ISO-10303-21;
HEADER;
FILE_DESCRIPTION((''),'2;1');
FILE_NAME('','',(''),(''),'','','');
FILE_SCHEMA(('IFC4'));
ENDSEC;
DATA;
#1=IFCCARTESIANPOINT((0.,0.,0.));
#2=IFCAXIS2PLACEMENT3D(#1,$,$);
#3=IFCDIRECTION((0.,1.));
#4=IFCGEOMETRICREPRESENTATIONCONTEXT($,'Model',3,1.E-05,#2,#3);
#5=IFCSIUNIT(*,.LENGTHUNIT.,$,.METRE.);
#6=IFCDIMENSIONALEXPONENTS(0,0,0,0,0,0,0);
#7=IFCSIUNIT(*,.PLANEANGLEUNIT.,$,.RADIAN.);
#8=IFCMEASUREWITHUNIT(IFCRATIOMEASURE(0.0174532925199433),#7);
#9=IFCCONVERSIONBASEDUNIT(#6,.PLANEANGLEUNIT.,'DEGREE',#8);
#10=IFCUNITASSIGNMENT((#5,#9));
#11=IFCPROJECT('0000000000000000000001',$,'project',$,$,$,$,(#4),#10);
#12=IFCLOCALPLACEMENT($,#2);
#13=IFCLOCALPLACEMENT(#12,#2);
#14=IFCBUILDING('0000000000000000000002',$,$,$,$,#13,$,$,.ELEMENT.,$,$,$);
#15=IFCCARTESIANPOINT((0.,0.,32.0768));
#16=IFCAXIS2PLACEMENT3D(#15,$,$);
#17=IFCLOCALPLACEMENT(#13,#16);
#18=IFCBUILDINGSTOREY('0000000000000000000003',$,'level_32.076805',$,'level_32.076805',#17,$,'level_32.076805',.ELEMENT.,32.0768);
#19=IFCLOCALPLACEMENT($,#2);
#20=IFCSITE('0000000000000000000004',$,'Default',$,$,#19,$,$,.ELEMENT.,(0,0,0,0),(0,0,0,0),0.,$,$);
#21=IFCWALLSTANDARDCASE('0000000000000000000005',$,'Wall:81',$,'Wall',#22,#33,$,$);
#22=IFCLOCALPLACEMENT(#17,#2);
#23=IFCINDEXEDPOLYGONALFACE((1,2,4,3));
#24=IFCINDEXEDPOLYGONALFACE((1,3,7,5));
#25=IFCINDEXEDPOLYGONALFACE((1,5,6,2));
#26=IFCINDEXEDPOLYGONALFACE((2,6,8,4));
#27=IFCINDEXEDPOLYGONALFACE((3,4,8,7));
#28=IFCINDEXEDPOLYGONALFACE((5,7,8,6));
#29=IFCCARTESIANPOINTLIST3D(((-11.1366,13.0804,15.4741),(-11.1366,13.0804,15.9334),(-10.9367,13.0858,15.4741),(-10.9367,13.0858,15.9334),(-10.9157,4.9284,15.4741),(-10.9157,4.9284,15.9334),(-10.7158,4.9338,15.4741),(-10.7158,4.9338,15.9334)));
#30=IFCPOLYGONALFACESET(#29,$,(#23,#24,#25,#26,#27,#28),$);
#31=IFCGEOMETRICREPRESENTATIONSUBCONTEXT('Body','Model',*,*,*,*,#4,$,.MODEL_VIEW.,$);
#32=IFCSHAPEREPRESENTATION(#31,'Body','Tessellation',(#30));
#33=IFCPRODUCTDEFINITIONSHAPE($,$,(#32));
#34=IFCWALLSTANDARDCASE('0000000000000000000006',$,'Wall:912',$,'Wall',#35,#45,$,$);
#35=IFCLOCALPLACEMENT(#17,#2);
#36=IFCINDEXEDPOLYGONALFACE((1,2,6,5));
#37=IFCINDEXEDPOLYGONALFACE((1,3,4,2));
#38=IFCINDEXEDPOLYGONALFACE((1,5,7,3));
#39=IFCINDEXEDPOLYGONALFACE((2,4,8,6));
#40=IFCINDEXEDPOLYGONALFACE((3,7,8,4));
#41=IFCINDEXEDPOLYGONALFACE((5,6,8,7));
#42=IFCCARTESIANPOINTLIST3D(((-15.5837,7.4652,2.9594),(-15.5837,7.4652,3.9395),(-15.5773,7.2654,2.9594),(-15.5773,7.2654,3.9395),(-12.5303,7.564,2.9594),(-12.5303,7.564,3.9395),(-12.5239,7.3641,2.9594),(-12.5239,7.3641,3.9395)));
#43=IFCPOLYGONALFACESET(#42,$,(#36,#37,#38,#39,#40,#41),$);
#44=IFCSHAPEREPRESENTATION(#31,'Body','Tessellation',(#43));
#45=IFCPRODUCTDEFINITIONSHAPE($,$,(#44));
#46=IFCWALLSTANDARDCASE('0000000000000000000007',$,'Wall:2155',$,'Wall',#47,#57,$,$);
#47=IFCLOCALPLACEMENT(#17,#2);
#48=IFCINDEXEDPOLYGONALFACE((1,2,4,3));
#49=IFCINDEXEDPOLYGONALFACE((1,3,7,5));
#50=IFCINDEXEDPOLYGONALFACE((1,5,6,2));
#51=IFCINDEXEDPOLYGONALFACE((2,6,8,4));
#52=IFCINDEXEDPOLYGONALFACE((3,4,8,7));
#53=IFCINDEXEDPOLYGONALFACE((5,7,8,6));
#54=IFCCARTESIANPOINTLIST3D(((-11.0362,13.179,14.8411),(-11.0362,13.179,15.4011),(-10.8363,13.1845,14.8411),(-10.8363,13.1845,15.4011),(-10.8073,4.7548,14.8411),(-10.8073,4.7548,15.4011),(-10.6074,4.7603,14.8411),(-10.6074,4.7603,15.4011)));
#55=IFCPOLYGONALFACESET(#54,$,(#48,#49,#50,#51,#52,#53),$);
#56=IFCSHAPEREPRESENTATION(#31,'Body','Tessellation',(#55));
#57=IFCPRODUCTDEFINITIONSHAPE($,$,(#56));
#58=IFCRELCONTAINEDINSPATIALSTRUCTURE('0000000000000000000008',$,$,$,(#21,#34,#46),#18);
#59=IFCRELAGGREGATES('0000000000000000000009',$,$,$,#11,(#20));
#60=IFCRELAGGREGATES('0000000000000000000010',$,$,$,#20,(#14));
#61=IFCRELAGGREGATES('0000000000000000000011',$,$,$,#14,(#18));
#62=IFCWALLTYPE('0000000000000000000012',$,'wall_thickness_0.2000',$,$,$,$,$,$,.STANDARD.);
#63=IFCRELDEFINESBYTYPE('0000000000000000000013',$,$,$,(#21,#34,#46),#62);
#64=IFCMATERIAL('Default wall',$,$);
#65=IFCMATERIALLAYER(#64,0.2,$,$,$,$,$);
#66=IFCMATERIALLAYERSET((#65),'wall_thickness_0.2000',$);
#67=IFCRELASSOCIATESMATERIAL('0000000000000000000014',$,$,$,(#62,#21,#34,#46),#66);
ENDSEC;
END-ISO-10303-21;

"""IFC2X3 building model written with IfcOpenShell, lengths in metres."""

from ifc_helpers import new_model, entity, si_unit, converted_unit, direction, frame, origin, place, context, subcontext, project, spatial, polyline, outline, extrude, material, layer, layer_set, layer_usage, type_object, element, save


model = new_model("IFC2X3")

# Units and contexts
model_context = context("Model", 3, precision=1e-05, world=origin(), true_north=direction((0.0, 1.0)))
body_context = subcontext(model_context, "Body", "Model", "MODEL_VIEW")
ifc_project = project(units=[si_unit("LENGTHUNIT", "METRE"), converted_unit("PLANEANGLEUNIT", "DEGREE", entity("IfcRatioMeasure", 0.0174532925199433), si_unit("PLANEANGLEUNIT", "RADIAN"), dimensions=[0, 0, 0, 0, 0, 0, 0])], contexts=[model_context])

# Site, building, storey
site_placement = place(None, origin())
site = spatial("IfcSite", under=ifc_project, at=site_placement, Name="Default", CompositionType="ELEMENT", RefLatitude=(0, 0, 0, 0), RefLongitude=(0, 0, 0, 0), RefElevation=0.0)
placement_1 = place(None, origin())
building_placement = place(placement_1, origin())
building = spatial("IfcBuilding", under=site, at=building_placement, CompositionType="ELEMENT")
storey_placement = place(building_placement, frame((0.0, 0.0, 32.0768)))
storey = spatial("IfcBuildingStorey", under=building, at=storey_placement, Name="level_32.076805", ObjectType="level_32.076805", LongName="level_32.076805", CompositionType="ELEMENT", Elevation=32.0768)

# Walls
ifc_material_1 = material(Name="Default wall")
ifc_layer = layer(ifc_material_1, 0.2)
ifc_layer_set = layer_set([ifc_layer], Name="wall_thickness_0.2000")
ifc_layer_usage = layer_usage(ifc_layer_set, "AXIS2", "POSITIVE", -0.1)
wall_type = type_object("IfcWallType", Name="wall_thickness_0.2000", PredefinedType="STANDARD", material=ifc_layer_set)
placement_2 = place(building_placement, frame((0.0, 0.0, 47.5509)))
wall_1_placement = place(placement_2, frame((-11.0366, 13.0831, 0.0), z_axis=(0.0, 0.0, 1.0), x_axis=(0.027088, -0.999633, 0.0)))
element("IfcWallStandardCase", 1, at=wall_1_placement, inside=storey, type_object=wall_type, material=ifc_layer_usage, Name="Wall:81", ObjectType="Wall", context=body_context, shape_type="SweptSolid", body=[
    extrude(outline(polyline([(8.155, -0.1), (8.155, 0.1), (0.0, 0.1), (0.0, -0.1), (8.155, -0.1)])), origin(), (0.0, 0.0, 1.0), 0.4593),
])
placement_3 = place(building_placement, frame((0.0, 0.0, 35.0362)))
wall_2_placement = place(placement_3, frame((-15.5805, 7.3653, 0.0), z_axis=(0.0, 0.0, 1.0), x_axis=(0.999477, 0.032325, 0.0)))
element("IfcWallStandardCase", 2, at=wall_2_placement, inside=storey, type_object=wall_type, material=ifc_layer_usage, Name="Wall:912", ObjectType="Wall", context=body_context, shape_type="SweptSolid", body=[
    extrude(outline(polyline([(3.055, -0.1), (3.055, 0.1), (0.0, 0.1), (0.0, -0.1), (3.055, -0.1)])), origin(), (0.0, 0.0, 1.0), 0.9802),
])

# Wall
placement_4 = place(building_placement, frame((0.0, 0.0, 46.9179)))
wall_3_placement = place(placement_4, frame((-10.9363, 13.1818, 0.0), z_axis=(0.0, 0.0, 1.0), x_axis=(0.027163, -0.999631, 0.0)))
element("IfcWallStandardCase", 3, at=wall_3_placement, inside=storey, type_object=wall_type, material=ifc_layer_usage, Name="Wall:2155", ObjectType="Wall", context=body_context, shape_type="SweptSolid", body=[
    extrude(outline(polyline([(8.4273, -0.1), (8.4273, 0.1), (0.0, 0.1), (0.0, -0.1), (8.4273, -0.1)])), origin(), (0.0, 0.0, 1.0), 0.56),
])

save(model, "model.ifc")
